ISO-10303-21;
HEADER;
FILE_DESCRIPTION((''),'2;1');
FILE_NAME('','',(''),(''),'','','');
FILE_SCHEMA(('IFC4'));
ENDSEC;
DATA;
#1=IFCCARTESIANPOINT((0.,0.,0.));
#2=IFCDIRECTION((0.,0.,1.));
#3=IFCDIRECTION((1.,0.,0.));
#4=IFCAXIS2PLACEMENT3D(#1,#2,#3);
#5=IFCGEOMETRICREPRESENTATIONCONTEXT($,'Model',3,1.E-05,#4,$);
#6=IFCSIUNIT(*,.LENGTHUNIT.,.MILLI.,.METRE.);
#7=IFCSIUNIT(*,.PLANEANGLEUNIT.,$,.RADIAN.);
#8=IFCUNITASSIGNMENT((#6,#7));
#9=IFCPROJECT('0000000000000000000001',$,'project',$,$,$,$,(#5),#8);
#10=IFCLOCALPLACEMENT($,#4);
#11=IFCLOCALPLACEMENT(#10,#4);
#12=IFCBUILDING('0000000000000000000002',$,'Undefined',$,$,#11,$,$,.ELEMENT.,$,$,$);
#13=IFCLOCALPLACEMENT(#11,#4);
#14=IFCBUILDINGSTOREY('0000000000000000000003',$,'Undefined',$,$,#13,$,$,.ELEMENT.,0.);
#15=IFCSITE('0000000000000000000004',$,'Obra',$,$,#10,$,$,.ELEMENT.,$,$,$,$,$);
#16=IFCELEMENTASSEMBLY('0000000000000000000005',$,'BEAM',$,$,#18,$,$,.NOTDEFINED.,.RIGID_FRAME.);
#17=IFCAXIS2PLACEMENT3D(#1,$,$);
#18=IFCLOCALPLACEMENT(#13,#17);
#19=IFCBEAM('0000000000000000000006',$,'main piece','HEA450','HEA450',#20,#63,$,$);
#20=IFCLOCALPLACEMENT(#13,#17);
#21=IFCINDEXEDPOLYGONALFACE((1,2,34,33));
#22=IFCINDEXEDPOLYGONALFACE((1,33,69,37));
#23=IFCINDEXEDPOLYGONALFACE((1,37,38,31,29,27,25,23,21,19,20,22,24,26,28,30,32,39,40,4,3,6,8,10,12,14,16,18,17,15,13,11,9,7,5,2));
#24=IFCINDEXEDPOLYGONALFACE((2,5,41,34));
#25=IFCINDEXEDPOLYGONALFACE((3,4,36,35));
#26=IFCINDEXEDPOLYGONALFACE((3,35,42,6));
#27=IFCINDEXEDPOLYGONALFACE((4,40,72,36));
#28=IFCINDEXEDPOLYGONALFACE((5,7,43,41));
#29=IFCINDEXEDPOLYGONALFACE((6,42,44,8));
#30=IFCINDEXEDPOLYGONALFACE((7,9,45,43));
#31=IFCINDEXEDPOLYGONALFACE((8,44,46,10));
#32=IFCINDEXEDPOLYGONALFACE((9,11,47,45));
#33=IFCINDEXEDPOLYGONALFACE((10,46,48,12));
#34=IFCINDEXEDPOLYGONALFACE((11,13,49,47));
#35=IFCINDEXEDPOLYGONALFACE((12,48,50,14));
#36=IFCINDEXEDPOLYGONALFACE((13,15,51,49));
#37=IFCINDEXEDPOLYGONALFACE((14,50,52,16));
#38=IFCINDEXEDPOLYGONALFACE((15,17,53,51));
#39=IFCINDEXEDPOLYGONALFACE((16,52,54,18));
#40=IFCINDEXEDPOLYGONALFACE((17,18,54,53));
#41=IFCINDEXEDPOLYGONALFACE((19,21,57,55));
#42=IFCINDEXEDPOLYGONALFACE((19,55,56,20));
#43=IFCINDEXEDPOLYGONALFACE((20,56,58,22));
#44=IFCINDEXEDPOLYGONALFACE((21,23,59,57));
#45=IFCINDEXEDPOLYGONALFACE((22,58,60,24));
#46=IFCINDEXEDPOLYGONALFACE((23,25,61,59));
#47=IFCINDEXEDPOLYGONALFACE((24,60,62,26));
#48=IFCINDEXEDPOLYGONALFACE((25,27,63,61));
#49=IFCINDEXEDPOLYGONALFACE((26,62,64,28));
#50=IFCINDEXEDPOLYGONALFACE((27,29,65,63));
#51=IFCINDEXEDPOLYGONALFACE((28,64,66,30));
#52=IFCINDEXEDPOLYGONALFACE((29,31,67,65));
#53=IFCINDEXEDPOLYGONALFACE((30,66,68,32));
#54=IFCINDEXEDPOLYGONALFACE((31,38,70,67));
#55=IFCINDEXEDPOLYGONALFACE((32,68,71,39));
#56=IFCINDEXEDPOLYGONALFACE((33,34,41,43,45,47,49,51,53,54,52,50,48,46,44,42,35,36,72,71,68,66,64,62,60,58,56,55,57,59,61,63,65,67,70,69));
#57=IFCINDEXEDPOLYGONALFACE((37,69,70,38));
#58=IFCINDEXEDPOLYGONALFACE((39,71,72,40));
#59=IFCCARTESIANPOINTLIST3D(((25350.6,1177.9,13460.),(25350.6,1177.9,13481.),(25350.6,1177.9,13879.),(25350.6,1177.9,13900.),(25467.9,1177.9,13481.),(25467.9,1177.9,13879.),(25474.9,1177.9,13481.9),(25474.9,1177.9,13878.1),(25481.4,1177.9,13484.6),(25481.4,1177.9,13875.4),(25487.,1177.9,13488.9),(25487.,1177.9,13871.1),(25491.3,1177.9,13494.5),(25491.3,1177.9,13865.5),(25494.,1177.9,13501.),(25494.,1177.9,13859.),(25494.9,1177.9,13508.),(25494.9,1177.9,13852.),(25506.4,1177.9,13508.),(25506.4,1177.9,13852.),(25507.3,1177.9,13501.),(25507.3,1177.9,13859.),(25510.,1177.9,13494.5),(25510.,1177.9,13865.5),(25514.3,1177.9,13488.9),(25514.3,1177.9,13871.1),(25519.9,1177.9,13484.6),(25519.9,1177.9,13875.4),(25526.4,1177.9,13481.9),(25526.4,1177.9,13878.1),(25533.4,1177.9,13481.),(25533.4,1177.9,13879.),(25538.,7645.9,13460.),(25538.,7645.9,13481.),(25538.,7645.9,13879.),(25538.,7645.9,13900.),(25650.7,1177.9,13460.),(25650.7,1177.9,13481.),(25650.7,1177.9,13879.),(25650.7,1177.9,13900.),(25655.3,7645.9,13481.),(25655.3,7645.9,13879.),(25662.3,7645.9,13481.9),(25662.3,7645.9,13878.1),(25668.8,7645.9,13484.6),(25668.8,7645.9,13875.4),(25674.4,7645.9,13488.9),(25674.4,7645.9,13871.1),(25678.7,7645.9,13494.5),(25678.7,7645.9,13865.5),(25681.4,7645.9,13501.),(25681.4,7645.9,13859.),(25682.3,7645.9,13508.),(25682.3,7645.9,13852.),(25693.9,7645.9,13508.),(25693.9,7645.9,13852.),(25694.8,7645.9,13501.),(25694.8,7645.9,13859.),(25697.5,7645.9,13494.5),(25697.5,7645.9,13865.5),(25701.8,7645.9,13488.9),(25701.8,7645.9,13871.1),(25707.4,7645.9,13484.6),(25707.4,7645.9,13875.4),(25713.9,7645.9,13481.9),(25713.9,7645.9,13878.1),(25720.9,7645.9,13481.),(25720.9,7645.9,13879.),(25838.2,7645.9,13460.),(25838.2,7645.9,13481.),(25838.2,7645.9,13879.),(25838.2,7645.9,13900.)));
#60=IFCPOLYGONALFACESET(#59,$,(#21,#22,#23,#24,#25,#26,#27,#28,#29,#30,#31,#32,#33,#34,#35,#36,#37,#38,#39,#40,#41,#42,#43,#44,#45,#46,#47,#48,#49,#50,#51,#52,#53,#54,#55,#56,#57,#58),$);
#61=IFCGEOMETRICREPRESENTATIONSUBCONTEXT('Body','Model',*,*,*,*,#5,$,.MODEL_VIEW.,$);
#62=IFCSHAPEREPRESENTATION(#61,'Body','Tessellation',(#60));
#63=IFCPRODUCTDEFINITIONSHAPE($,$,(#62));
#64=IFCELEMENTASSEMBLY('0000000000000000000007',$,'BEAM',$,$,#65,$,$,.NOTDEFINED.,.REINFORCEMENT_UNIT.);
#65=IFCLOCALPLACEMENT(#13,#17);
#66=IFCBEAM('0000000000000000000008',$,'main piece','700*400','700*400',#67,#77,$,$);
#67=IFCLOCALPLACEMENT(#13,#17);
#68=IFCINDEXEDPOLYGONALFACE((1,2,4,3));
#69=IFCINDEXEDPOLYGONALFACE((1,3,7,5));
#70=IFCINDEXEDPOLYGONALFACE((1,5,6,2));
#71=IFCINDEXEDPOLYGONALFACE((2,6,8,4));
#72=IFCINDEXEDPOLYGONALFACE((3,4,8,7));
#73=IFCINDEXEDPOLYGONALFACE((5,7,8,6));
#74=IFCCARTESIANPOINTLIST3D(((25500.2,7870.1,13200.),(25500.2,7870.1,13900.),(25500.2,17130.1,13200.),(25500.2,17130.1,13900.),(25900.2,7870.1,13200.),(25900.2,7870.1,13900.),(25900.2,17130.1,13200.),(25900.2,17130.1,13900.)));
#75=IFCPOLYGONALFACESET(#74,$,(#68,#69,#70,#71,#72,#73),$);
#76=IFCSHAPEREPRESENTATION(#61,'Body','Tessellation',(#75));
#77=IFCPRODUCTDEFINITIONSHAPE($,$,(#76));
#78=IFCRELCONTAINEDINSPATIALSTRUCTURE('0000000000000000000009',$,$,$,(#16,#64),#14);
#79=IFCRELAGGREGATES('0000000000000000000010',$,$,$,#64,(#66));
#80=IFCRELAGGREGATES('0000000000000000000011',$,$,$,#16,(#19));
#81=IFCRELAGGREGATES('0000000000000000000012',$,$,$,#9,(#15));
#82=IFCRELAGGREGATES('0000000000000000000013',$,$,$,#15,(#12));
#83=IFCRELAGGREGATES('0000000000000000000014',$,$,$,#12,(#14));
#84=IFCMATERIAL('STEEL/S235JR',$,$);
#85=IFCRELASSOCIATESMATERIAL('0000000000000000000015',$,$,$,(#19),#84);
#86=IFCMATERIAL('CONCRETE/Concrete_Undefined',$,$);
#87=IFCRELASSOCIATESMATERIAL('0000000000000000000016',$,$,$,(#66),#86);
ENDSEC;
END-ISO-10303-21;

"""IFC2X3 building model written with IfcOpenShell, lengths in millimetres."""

from ifc_helpers import new_model, si_unit, frame, origin_with_axes, origin_2d_with_axis, place, context, subcontext, project, spatial, rectangle, i_section, extrude, clip, halfspace, material, element, aggregate, save


model = new_model("IFC2X3")

# Units and contexts
model_context = context("Model", 3, precision=1e-05, world=origin_with_axes())
body_context = subcontext(model_context, "Body", "Model", "MODEL_VIEW")
ifc_project = project(units=[si_unit("LENGTHUNIT", "METRE", prefix="MILLI"), si_unit("PLANEANGLEUNIT", "RADIAN")], contexts=[model_context])

# Site, building, storey
site_placement = place(None, origin_with_axes())
site = spatial("IfcSite", under=ifc_project, at=site_placement, Name="Obra", CompositionType="ELEMENT")
building_placement = place(site_placement, origin_with_axes())
building = spatial("IfcBuilding", under=site, at=building_placement, Name="Undefined", CompositionType="ELEMENT")
storey_placement = place(building_placement, origin_with_axes())
storey = spatial("IfcBuildingStorey", under=building, at=storey_placement, Name="Undefined", CompositionType="ELEMENT", Elevation=0.0)

# Element assemblies, beams
assembly_1_placement = place(storey_placement, origin_with_axes())
assembly_1 = element("IfcElementAssembly", 1, at=assembly_1_placement, inside=storey, Name="BEAM", AssemblyPlace="NOTDEFINED", PredefinedType="RIGID_FRAME")
ifc_material_1 = material(Name="STEEL/S235JR")
beam_1_placement = place(assembly_1_placement, frame((25688.8, 7670.2, 13680.0), z_axis=(0.0, 0.0, 1.0), x_axis=(-0.028967, -0.99958, 0.0)))
beam_1 = element("IfcBeam", 2, at=beam_1_placement, material=ifc_material_1, Name="main piece", Description="HEA450", ObjectType="HEA450", context=body_context, shape_type="Clipping", body=[
    clip(clip(extrude(i_section(OverallWidth=300.0, OverallDepth=440.0, WebThickness=11.5, FlangeThickness=21.0, FilletRadius=27.0, at=origin_2d_with_axis()), frame((6503.9, 0.0, 0.0), z_axis=(-1.0, 0.0, 0.0), x_axis=(0.0, -1.0, 0.0)), (0.0, 0.0, 1.0), 6488.3), halfspace(frame((6490.7, 150.0, 0.0), z_axis=(-0.99958, -0.028967, 0.0), x_axis=(0.0, 0.0, 1.0)), True)), halfspace(frame((28.7, -150.0, 0.0), z_axis=(0.99958, 0.028967, 0.0), x_axis=(0.0, 0.0, 1.0)), True)),
])
assembly_2_placement = place(storey_placement, origin_with_axes())
assembly_2 = element("IfcElementAssembly", 3, at=assembly_2_placement, inside=storey, Name="BEAM", AssemblyPlace="NOTDEFINED", PredefinedType="REINFORCEMENT_UNIT")
ifc_material_2 = material(Name="CONCRETE/Concrete_Undefined")
beam_2_placement = place(assembly_2_placement, frame((25700.2, 7870.1, 13550.0), z_axis=(0.0, 0.0, 1.0), x_axis=(0.0, 1.0, 0.0)))
beam_2 = element("IfcBeam", 4, at=beam_2_placement, material=ifc_material_2, Name="main piece", Description="700*400", ObjectType="700*400", context=body_context, shape_type="SweptSolid", body=[
    extrude(rectangle(XDim=400.0, YDim=700.0, at=origin_2d_with_axis()), frame((9260.0, 0.0, 0.0), z_axis=(-1.0, 0.0, 0.0), x_axis=(0.0, -1.0, 0.0)), (0.0, 0.0, 1.0), 9260.0),
])
aggregate(assembly_2, [beam_2])

aggregate(assembly_1, [beam_1])

save(model, "model.ifc")
